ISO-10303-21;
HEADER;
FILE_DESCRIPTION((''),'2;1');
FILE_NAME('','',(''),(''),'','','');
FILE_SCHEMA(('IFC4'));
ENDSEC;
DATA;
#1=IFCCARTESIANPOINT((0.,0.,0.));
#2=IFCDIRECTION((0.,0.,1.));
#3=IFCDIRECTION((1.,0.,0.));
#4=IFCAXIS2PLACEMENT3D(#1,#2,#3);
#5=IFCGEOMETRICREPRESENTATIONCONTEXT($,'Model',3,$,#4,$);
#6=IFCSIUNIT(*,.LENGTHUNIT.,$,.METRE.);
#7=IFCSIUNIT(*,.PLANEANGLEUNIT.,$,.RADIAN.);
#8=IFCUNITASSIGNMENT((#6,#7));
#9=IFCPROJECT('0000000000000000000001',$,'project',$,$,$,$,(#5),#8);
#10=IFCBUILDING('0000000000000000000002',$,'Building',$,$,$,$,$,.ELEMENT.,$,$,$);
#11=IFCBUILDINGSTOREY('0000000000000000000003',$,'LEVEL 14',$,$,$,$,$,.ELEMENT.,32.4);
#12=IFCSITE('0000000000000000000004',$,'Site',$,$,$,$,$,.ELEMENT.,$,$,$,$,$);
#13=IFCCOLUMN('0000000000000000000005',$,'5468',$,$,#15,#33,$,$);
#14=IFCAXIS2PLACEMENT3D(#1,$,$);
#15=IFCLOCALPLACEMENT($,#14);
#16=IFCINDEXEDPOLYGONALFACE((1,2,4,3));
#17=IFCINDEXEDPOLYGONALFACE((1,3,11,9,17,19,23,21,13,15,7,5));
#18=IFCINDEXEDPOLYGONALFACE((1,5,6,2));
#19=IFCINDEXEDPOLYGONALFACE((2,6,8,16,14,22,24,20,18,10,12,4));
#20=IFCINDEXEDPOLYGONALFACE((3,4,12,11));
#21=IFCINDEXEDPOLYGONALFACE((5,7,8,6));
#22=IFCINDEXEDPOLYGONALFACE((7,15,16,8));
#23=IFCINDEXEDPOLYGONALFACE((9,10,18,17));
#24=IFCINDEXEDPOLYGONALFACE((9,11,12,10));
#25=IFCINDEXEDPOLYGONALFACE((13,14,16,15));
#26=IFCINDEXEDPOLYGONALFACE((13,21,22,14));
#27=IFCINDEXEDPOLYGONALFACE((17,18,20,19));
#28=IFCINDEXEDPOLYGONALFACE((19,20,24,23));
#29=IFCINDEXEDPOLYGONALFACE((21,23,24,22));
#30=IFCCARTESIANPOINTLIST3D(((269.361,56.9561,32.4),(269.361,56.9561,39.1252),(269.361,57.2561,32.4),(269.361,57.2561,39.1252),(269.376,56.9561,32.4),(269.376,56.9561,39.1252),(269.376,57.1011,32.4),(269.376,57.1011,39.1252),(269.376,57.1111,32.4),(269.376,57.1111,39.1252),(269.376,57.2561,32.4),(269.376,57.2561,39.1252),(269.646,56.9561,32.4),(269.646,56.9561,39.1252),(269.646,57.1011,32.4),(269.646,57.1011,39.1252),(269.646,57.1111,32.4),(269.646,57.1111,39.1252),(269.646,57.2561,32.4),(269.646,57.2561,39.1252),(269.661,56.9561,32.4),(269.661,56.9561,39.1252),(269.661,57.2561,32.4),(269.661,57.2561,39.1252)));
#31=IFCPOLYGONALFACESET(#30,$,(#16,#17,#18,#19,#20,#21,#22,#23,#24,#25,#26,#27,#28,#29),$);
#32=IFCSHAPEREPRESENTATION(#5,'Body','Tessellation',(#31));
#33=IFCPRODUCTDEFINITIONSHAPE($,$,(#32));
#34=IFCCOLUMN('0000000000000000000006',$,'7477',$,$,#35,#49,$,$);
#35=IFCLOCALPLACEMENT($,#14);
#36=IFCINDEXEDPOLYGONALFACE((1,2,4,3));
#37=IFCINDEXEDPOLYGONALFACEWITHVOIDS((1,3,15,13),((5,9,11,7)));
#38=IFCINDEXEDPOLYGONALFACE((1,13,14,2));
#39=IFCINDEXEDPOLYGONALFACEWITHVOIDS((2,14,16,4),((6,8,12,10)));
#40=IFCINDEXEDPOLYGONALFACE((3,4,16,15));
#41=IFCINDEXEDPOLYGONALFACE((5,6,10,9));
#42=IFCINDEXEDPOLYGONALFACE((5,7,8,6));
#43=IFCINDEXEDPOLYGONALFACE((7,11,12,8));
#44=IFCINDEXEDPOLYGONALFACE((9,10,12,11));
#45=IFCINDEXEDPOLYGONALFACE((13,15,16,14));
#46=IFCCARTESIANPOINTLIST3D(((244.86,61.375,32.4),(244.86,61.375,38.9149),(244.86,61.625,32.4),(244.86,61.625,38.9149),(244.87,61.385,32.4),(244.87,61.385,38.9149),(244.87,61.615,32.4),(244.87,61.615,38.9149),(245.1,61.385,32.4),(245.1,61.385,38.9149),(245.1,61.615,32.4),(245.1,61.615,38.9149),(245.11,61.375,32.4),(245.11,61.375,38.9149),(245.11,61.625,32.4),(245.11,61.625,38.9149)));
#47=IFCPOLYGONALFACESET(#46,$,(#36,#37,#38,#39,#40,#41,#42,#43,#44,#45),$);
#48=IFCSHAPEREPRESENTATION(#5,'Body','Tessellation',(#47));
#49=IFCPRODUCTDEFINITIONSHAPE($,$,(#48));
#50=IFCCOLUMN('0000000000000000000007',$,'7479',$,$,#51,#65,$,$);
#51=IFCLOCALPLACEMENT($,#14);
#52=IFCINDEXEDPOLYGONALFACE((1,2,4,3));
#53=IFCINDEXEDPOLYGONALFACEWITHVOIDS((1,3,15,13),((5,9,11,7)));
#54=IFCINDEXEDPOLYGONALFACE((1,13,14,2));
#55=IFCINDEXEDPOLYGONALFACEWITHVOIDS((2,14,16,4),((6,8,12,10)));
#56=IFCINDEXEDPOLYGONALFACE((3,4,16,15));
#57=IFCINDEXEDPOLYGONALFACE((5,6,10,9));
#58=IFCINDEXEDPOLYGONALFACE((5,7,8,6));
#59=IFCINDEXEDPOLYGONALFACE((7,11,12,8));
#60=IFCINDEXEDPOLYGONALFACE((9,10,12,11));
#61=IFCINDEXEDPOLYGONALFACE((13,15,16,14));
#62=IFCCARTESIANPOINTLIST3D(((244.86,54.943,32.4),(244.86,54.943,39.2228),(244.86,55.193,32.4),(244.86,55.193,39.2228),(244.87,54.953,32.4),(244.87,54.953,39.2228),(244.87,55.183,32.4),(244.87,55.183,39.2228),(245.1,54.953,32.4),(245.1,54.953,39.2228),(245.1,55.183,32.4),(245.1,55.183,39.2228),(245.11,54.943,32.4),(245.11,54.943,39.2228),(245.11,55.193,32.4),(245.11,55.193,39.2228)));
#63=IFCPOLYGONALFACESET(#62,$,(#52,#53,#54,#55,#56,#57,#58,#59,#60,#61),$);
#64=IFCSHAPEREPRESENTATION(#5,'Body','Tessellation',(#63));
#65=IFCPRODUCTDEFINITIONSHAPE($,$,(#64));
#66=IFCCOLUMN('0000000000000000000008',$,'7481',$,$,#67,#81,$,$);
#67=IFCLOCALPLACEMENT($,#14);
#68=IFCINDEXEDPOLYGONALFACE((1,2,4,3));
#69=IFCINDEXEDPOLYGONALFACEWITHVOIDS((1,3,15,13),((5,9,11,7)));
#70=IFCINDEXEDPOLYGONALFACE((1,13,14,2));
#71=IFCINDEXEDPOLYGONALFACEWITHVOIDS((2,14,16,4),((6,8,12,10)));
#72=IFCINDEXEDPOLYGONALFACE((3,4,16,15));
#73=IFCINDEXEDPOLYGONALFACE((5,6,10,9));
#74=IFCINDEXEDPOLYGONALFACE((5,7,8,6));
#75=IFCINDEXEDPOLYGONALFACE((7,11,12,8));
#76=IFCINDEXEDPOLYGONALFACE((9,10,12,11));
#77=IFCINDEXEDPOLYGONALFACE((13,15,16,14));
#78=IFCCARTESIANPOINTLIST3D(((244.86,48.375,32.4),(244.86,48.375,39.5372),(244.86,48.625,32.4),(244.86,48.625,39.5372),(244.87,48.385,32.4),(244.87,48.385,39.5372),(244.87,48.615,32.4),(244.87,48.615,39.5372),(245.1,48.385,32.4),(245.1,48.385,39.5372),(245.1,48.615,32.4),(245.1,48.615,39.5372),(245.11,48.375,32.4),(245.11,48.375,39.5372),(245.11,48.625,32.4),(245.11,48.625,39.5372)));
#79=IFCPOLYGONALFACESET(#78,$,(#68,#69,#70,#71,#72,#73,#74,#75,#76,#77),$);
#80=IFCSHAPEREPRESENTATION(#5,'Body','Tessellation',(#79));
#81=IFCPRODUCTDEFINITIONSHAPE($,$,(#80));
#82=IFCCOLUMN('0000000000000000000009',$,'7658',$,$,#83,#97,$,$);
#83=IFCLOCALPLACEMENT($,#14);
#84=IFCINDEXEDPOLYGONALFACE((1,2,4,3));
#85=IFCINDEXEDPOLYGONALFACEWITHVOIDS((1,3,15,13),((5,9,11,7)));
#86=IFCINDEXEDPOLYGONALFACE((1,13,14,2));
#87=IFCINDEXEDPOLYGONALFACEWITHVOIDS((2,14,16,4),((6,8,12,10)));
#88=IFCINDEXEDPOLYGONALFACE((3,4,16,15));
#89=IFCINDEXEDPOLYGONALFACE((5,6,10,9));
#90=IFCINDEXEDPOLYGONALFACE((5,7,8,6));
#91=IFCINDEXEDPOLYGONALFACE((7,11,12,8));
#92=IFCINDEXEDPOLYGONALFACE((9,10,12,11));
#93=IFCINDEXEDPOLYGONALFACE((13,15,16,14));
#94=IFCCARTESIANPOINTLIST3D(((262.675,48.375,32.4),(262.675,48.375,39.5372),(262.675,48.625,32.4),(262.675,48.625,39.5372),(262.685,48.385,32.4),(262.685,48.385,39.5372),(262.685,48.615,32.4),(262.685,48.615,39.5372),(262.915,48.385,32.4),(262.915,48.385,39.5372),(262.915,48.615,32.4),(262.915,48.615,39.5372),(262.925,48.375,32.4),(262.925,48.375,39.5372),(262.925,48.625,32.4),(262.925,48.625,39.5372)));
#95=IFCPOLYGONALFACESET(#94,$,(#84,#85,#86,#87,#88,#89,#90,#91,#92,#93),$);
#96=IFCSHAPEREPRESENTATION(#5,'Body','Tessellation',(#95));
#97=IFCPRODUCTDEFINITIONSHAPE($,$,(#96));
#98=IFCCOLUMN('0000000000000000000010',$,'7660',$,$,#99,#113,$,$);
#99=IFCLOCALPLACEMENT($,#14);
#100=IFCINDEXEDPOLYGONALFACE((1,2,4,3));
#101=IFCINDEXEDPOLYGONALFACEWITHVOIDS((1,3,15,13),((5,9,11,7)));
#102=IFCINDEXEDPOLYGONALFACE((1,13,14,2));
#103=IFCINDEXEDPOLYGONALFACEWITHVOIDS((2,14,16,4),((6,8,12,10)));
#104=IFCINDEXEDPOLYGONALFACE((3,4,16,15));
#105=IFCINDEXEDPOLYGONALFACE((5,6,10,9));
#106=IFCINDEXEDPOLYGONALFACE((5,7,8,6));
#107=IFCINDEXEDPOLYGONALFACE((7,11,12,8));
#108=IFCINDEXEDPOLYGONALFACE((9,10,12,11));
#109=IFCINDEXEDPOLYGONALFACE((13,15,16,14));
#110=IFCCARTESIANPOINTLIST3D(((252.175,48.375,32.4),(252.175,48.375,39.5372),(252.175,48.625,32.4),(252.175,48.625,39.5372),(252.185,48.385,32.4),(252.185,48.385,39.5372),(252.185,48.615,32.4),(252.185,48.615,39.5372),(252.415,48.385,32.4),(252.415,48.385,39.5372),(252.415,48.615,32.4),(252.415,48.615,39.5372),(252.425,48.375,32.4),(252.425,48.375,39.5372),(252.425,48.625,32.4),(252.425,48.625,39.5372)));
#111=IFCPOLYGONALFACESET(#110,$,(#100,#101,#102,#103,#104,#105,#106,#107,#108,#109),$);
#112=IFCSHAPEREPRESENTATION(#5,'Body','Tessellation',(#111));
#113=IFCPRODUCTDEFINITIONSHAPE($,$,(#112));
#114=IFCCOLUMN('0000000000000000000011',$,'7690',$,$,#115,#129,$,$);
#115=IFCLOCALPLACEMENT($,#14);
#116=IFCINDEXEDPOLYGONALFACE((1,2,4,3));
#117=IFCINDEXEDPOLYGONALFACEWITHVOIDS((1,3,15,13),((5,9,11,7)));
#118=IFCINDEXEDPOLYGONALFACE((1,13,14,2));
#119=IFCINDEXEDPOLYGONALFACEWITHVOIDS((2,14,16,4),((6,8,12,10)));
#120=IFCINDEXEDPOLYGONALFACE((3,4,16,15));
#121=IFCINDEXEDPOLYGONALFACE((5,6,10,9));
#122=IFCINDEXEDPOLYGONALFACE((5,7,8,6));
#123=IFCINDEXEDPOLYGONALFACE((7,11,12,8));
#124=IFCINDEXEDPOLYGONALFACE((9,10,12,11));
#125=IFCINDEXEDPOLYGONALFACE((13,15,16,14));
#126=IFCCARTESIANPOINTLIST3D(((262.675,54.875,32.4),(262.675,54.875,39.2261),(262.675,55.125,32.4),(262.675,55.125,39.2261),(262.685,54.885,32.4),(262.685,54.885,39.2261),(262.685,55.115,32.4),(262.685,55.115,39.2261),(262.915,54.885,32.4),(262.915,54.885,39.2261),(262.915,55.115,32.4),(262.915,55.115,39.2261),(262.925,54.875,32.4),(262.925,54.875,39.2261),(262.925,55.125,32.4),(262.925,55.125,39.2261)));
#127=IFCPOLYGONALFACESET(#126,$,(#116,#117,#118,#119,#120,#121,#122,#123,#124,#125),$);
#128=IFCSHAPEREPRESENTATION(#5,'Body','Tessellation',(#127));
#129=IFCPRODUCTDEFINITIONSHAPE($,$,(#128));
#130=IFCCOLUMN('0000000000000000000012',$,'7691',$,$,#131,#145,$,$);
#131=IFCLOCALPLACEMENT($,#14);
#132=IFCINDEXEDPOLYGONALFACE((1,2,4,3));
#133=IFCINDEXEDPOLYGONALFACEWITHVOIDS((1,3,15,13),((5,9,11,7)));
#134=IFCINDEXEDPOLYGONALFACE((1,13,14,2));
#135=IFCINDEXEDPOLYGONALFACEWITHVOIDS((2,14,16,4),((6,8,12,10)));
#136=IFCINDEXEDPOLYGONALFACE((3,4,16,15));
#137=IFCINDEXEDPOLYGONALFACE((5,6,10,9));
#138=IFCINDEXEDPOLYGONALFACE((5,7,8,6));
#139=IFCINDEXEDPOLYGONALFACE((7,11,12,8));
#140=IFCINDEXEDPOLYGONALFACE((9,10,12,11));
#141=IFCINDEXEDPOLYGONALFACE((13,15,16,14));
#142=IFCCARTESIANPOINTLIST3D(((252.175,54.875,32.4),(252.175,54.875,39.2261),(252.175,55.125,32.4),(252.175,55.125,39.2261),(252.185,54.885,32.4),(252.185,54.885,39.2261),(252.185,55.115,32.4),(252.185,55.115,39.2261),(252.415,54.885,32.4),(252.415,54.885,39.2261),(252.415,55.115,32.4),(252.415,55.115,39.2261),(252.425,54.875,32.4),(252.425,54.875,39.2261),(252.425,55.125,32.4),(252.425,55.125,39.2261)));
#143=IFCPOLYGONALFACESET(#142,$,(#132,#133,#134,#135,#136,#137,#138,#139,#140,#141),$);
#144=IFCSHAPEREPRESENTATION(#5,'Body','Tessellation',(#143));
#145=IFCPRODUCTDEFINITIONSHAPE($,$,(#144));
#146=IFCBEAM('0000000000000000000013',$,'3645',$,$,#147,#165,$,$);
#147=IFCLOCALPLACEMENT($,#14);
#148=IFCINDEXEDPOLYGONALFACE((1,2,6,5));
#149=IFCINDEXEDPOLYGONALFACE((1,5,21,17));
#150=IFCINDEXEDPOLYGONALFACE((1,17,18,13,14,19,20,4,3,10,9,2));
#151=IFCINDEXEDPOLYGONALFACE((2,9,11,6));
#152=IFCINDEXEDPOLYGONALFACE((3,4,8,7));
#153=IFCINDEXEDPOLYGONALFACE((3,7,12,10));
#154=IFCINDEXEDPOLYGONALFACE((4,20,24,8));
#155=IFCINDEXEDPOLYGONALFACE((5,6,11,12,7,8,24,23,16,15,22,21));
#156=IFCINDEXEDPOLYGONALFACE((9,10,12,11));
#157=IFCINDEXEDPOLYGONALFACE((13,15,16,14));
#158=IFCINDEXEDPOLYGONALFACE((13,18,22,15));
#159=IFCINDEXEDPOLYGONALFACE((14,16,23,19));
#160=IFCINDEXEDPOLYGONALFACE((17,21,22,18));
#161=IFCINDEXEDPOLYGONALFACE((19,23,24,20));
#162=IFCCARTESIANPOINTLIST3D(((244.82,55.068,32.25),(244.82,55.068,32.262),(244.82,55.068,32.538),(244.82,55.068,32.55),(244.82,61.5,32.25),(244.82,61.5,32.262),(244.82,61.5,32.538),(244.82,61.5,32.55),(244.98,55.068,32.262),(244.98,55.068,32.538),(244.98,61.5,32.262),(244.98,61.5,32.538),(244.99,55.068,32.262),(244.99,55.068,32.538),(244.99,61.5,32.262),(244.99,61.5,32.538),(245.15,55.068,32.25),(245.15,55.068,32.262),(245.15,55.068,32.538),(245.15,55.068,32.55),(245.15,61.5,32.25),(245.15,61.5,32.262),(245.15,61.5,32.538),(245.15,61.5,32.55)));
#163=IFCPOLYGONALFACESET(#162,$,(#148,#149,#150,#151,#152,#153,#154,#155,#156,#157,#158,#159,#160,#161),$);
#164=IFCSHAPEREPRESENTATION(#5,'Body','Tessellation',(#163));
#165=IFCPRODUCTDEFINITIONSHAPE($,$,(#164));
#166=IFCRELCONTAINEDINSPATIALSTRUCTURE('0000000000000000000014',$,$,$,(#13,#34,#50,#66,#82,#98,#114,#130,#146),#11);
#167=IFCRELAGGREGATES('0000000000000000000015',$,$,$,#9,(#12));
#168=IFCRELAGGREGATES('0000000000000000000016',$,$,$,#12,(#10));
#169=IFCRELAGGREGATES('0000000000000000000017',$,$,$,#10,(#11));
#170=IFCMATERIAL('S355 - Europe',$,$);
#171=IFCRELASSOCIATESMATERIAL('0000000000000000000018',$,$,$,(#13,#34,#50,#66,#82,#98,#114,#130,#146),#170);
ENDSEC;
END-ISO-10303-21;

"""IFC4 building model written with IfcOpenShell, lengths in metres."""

from ifc_helpers import new_model, si_unit, frame, origin_with_axes, origin_2d_with_axis, place, context, project, spatial, hollow_rectangle, i_section, extrude, material, material_profile, profile_set, profile_usage, element, save


model = new_model("IFC4")

# Units and contexts
model_context = context("Model", 3, world=origin_with_axes())
ifc_project = project(units=[si_unit("LENGTHUNIT", "METRE"), si_unit("PLANEANGLEUNIT", "RADIAN")], contexts=[model_context])

# Site, building, storey
site = spatial("IfcSite", under=ifc_project, Name="Site", CompositionType="ELEMENT")
building = spatial("IfcBuilding", under=site, Name="Building", CompositionType="ELEMENT")
storey = spatial("IfcBuildingStorey", under=building, Name="LEVEL 14", CompositionType="ELEMENT", Elevation=32.4)

# Columns
ifc_material = material(Name="S355 - Europe")
ifc_material_profile_1 = material_profile(ifc_material, i_section(OverallWidth=0.3, OverallDepth=0.3, WebThickness=0.01, FlangeThickness=0.015, at=origin_2d_with_axis()))
ifc_profile_set_1 = profile_set([ifc_material_profile_1])
ifc_profile_usage_1 = profile_usage(ifc_profile_set_1, cardinal=10)
column_1_placement = place(None, frame((269.511, 57.1061, 32.4), z_axis=(0.0, 0.0, 1.0), x_axis=(0.0, -1.0, 0.0)))
element("IfcColumn", 1, at=column_1_placement, inside=storey, material=ifc_profile_usage_1, Name="5468", context=model_context, shape_type="SweptSolid", body=[
    extrude(i_section(OverallWidth=0.3, OverallDepth=0.3, WebThickness=0.01, FlangeThickness=0.015, at=origin_2d_with_axis()), origin_with_axes(), (0.0, 0.0, 1.0), 6.7252),
])
ifc_material_profile_2 = material_profile(ifc_material, hollow_rectangle(XDim=0.25, YDim=0.25, WallThickness=0.01, at=origin_2d_with_axis()))
ifc_profile_set_2 = profile_set([ifc_material_profile_2])
ifc_profile_usage_2 = profile_usage(ifc_profile_set_2, cardinal=10)
column_2_placement = place(None, frame((244.985, 61.5, 32.4), z_axis=(0.0, 0.0, 1.0), x_axis=(0.0, -1.0, 0.0)))
element("IfcColumn", 2, at=column_2_placement, inside=storey, material=ifc_profile_usage_2, Name="7477", context=model_context, shape_type="SweptSolid", body=[
    extrude(hollow_rectangle(XDim=0.25, YDim=0.25, WallThickness=0.01, at=origin_2d_with_axis()), origin_with_axes(), (0.0, 0.0, 1.0), 6.5149),
])
ifc_material_profile_3 = material_profile(ifc_material, hollow_rectangle(XDim=0.25, YDim=0.25, WallThickness=0.01, at=origin_2d_with_axis()))
ifc_profile_set_3 = profile_set([ifc_material_profile_3])
ifc_profile_usage_3 = profile_usage(ifc_profile_set_3, cardinal=10)
column_3_placement = place(None, frame((244.985, 55.068, 32.4), z_axis=(0.0, 0.0, 1.0), x_axis=(0.0, -1.0, 0.0)))
element("IfcColumn", 3, at=column_3_placement, inside=storey, material=ifc_profile_usage_3, Name="7479", context=model_context, shape_type="SweptSolid", body=[
    extrude(hollow_rectangle(XDim=0.25, YDim=0.25, WallThickness=0.01, at=origin_2d_with_axis()), origin_with_axes(), (0.0, 0.0, 1.0), 6.8228),
])
ifc_material_profile_4 = material_profile(ifc_material, hollow_rectangle(XDim=0.25, YDim=0.25, WallThickness=0.01, at=origin_2d_with_axis()))
ifc_profile_set_4 = profile_set([ifc_material_profile_4])
ifc_profile_usage_4 = profile_usage(ifc_profile_set_4, cardinal=10)
column_4_placement = place(None, frame((244.985, 48.5, 32.4), z_axis=(0.0, 0.0, 1.0), x_axis=(0.0, -1.0, 0.0)))
element("IfcColumn", 4, at=column_4_placement, inside=storey, material=ifc_profile_usage_4, Name="7481", context=model_context, shape_type="SweptSolid", body=[
    extrude(hollow_rectangle(XDim=0.25, YDim=0.25, WallThickness=0.01, at=origin_2d_with_axis()), origin_with_axes(), (0.0, 0.0, 1.0), 7.1372),
])
ifc_material_profile_5 = material_profile(ifc_material, hollow_rectangle(XDim=0.25, YDim=0.25, WallThickness=0.01, at=origin_2d_with_axis()))
ifc_profile_set_5 = profile_set([ifc_material_profile_5])
ifc_profile_usage_5 = profile_usage(ifc_profile_set_5, cardinal=10)
column_5_placement = place(None, frame((262.8, 48.5, 32.4), z_axis=(0.0, 0.0, 1.0), x_axis=(0.0, -1.0, 0.0)))
element("IfcColumn", 5, at=column_5_placement, inside=storey, material=ifc_profile_usage_5, Name="7658", context=model_context, shape_type="SweptSolid", body=[
    extrude(hollow_rectangle(XDim=0.25, YDim=0.25, WallThickness=0.01, at=origin_2d_with_axis()), origin_with_axes(), (0.0, 0.0, 1.0), 7.1372),
])
ifc_material_profile_6 = material_profile(ifc_material, hollow_rectangle(XDim=0.25, YDim=0.25, WallThickness=0.01, at=origin_2d_with_axis()))
ifc_profile_set_6 = profile_set([ifc_material_profile_6])
ifc_profile_usage_6 = profile_usage(ifc_profile_set_6, cardinal=10)
column_6_placement = place(None, frame((252.3, 48.5, 32.4), z_axis=(0.0, 0.0, 1.0), x_axis=(0.0, -1.0, 0.0)))
element("IfcColumn", 6, at=column_6_placement, inside=storey, material=ifc_profile_usage_6, Name="7660", context=model_context, shape_type="SweptSolid", body=[
    extrude(hollow_rectangle(XDim=0.25, YDim=0.25, WallThickness=0.01, at=origin_2d_with_axis()), origin_with_axes(), (0.0, 0.0, 1.0), 7.1372),
])
ifc_material_profile_7 = material_profile(ifc_material, hollow_rectangle(XDim=0.25, YDim=0.25, WallThickness=0.01, at=origin_2d_with_axis()))
ifc_profile_set_7 = profile_set([ifc_material_profile_7])
ifc_profile_usage_7 = profile_usage(ifc_profile_set_7, cardinal=10)
column_7_placement = place(None, frame((262.8, 55.0, 32.4), z_axis=(0.0, 0.0, 1.0), x_axis=(0.0, -1.0, 0.0)))
element("IfcColumn", 7, at=column_7_placement, inside=storey, material=ifc_profile_usage_7, Name="7690", context=model_context, shape_type="SweptSolid", body=[
    extrude(hollow_rectangle(XDim=0.25, YDim=0.25, WallThickness=0.01, at=origin_2d_with_axis()), origin_with_axes(), (0.0, 0.0, 1.0), 6.8261),
])
ifc_material_profile_8 = material_profile(ifc_material, hollow_rectangle(XDim=0.25, YDim=0.25, WallThickness=0.01, at=origin_2d_with_axis()))
ifc_profile_set_8 = profile_set([ifc_material_profile_8])
ifc_profile_usage_8 = profile_usage(ifc_profile_set_8, cardinal=10)
column_8_placement = place(None, frame((252.3, 55.0, 32.4), z_axis=(0.0, 0.0, 1.0), x_axis=(0.0, -1.0, 0.0)))
element("IfcColumn", 8, at=column_8_placement, inside=storey, material=ifc_profile_usage_8, Name="7691", context=model_context, shape_type="SweptSolid", body=[
    extrude(hollow_rectangle(XDim=0.25, YDim=0.25, WallThickness=0.01, at=origin_2d_with_axis()), origin_with_axes(), (0.0, 0.0, 1.0), 6.8261),
])

# Beam
ifc_material_profile_9 = material_profile(ifc_material, i_section(OverallWidth=0.33, OverallDepth=0.3, WebThickness=0.01, FlangeThickness=0.012, at=origin_2d_with_axis()))
ifc_profile_set_9 = profile_set([ifc_material_profile_9])
ifc_profile_usage_9 = profile_usage(ifc_profile_set_9, cardinal=10)
beam_1_placement = place(None, frame((244.985, 61.5, 32.4), z_axis=(0.0, -1.0, 0.0), x_axis=(1.0, 0.0, 0.0)))
element("IfcBeam", 9, at=beam_1_placement, inside=storey, material=ifc_profile_usage_9, Name="3645", context=model_context, shape_type="SweptSolid", body=[
    extrude(i_section(OverallWidth=0.33, OverallDepth=0.3, WebThickness=0.01, FlangeThickness=0.012, at=origin_2d_with_axis()), origin_with_axes(), (0.0, 0.0, 1.0), 6.432),
])

save(model, "model.ifc")
